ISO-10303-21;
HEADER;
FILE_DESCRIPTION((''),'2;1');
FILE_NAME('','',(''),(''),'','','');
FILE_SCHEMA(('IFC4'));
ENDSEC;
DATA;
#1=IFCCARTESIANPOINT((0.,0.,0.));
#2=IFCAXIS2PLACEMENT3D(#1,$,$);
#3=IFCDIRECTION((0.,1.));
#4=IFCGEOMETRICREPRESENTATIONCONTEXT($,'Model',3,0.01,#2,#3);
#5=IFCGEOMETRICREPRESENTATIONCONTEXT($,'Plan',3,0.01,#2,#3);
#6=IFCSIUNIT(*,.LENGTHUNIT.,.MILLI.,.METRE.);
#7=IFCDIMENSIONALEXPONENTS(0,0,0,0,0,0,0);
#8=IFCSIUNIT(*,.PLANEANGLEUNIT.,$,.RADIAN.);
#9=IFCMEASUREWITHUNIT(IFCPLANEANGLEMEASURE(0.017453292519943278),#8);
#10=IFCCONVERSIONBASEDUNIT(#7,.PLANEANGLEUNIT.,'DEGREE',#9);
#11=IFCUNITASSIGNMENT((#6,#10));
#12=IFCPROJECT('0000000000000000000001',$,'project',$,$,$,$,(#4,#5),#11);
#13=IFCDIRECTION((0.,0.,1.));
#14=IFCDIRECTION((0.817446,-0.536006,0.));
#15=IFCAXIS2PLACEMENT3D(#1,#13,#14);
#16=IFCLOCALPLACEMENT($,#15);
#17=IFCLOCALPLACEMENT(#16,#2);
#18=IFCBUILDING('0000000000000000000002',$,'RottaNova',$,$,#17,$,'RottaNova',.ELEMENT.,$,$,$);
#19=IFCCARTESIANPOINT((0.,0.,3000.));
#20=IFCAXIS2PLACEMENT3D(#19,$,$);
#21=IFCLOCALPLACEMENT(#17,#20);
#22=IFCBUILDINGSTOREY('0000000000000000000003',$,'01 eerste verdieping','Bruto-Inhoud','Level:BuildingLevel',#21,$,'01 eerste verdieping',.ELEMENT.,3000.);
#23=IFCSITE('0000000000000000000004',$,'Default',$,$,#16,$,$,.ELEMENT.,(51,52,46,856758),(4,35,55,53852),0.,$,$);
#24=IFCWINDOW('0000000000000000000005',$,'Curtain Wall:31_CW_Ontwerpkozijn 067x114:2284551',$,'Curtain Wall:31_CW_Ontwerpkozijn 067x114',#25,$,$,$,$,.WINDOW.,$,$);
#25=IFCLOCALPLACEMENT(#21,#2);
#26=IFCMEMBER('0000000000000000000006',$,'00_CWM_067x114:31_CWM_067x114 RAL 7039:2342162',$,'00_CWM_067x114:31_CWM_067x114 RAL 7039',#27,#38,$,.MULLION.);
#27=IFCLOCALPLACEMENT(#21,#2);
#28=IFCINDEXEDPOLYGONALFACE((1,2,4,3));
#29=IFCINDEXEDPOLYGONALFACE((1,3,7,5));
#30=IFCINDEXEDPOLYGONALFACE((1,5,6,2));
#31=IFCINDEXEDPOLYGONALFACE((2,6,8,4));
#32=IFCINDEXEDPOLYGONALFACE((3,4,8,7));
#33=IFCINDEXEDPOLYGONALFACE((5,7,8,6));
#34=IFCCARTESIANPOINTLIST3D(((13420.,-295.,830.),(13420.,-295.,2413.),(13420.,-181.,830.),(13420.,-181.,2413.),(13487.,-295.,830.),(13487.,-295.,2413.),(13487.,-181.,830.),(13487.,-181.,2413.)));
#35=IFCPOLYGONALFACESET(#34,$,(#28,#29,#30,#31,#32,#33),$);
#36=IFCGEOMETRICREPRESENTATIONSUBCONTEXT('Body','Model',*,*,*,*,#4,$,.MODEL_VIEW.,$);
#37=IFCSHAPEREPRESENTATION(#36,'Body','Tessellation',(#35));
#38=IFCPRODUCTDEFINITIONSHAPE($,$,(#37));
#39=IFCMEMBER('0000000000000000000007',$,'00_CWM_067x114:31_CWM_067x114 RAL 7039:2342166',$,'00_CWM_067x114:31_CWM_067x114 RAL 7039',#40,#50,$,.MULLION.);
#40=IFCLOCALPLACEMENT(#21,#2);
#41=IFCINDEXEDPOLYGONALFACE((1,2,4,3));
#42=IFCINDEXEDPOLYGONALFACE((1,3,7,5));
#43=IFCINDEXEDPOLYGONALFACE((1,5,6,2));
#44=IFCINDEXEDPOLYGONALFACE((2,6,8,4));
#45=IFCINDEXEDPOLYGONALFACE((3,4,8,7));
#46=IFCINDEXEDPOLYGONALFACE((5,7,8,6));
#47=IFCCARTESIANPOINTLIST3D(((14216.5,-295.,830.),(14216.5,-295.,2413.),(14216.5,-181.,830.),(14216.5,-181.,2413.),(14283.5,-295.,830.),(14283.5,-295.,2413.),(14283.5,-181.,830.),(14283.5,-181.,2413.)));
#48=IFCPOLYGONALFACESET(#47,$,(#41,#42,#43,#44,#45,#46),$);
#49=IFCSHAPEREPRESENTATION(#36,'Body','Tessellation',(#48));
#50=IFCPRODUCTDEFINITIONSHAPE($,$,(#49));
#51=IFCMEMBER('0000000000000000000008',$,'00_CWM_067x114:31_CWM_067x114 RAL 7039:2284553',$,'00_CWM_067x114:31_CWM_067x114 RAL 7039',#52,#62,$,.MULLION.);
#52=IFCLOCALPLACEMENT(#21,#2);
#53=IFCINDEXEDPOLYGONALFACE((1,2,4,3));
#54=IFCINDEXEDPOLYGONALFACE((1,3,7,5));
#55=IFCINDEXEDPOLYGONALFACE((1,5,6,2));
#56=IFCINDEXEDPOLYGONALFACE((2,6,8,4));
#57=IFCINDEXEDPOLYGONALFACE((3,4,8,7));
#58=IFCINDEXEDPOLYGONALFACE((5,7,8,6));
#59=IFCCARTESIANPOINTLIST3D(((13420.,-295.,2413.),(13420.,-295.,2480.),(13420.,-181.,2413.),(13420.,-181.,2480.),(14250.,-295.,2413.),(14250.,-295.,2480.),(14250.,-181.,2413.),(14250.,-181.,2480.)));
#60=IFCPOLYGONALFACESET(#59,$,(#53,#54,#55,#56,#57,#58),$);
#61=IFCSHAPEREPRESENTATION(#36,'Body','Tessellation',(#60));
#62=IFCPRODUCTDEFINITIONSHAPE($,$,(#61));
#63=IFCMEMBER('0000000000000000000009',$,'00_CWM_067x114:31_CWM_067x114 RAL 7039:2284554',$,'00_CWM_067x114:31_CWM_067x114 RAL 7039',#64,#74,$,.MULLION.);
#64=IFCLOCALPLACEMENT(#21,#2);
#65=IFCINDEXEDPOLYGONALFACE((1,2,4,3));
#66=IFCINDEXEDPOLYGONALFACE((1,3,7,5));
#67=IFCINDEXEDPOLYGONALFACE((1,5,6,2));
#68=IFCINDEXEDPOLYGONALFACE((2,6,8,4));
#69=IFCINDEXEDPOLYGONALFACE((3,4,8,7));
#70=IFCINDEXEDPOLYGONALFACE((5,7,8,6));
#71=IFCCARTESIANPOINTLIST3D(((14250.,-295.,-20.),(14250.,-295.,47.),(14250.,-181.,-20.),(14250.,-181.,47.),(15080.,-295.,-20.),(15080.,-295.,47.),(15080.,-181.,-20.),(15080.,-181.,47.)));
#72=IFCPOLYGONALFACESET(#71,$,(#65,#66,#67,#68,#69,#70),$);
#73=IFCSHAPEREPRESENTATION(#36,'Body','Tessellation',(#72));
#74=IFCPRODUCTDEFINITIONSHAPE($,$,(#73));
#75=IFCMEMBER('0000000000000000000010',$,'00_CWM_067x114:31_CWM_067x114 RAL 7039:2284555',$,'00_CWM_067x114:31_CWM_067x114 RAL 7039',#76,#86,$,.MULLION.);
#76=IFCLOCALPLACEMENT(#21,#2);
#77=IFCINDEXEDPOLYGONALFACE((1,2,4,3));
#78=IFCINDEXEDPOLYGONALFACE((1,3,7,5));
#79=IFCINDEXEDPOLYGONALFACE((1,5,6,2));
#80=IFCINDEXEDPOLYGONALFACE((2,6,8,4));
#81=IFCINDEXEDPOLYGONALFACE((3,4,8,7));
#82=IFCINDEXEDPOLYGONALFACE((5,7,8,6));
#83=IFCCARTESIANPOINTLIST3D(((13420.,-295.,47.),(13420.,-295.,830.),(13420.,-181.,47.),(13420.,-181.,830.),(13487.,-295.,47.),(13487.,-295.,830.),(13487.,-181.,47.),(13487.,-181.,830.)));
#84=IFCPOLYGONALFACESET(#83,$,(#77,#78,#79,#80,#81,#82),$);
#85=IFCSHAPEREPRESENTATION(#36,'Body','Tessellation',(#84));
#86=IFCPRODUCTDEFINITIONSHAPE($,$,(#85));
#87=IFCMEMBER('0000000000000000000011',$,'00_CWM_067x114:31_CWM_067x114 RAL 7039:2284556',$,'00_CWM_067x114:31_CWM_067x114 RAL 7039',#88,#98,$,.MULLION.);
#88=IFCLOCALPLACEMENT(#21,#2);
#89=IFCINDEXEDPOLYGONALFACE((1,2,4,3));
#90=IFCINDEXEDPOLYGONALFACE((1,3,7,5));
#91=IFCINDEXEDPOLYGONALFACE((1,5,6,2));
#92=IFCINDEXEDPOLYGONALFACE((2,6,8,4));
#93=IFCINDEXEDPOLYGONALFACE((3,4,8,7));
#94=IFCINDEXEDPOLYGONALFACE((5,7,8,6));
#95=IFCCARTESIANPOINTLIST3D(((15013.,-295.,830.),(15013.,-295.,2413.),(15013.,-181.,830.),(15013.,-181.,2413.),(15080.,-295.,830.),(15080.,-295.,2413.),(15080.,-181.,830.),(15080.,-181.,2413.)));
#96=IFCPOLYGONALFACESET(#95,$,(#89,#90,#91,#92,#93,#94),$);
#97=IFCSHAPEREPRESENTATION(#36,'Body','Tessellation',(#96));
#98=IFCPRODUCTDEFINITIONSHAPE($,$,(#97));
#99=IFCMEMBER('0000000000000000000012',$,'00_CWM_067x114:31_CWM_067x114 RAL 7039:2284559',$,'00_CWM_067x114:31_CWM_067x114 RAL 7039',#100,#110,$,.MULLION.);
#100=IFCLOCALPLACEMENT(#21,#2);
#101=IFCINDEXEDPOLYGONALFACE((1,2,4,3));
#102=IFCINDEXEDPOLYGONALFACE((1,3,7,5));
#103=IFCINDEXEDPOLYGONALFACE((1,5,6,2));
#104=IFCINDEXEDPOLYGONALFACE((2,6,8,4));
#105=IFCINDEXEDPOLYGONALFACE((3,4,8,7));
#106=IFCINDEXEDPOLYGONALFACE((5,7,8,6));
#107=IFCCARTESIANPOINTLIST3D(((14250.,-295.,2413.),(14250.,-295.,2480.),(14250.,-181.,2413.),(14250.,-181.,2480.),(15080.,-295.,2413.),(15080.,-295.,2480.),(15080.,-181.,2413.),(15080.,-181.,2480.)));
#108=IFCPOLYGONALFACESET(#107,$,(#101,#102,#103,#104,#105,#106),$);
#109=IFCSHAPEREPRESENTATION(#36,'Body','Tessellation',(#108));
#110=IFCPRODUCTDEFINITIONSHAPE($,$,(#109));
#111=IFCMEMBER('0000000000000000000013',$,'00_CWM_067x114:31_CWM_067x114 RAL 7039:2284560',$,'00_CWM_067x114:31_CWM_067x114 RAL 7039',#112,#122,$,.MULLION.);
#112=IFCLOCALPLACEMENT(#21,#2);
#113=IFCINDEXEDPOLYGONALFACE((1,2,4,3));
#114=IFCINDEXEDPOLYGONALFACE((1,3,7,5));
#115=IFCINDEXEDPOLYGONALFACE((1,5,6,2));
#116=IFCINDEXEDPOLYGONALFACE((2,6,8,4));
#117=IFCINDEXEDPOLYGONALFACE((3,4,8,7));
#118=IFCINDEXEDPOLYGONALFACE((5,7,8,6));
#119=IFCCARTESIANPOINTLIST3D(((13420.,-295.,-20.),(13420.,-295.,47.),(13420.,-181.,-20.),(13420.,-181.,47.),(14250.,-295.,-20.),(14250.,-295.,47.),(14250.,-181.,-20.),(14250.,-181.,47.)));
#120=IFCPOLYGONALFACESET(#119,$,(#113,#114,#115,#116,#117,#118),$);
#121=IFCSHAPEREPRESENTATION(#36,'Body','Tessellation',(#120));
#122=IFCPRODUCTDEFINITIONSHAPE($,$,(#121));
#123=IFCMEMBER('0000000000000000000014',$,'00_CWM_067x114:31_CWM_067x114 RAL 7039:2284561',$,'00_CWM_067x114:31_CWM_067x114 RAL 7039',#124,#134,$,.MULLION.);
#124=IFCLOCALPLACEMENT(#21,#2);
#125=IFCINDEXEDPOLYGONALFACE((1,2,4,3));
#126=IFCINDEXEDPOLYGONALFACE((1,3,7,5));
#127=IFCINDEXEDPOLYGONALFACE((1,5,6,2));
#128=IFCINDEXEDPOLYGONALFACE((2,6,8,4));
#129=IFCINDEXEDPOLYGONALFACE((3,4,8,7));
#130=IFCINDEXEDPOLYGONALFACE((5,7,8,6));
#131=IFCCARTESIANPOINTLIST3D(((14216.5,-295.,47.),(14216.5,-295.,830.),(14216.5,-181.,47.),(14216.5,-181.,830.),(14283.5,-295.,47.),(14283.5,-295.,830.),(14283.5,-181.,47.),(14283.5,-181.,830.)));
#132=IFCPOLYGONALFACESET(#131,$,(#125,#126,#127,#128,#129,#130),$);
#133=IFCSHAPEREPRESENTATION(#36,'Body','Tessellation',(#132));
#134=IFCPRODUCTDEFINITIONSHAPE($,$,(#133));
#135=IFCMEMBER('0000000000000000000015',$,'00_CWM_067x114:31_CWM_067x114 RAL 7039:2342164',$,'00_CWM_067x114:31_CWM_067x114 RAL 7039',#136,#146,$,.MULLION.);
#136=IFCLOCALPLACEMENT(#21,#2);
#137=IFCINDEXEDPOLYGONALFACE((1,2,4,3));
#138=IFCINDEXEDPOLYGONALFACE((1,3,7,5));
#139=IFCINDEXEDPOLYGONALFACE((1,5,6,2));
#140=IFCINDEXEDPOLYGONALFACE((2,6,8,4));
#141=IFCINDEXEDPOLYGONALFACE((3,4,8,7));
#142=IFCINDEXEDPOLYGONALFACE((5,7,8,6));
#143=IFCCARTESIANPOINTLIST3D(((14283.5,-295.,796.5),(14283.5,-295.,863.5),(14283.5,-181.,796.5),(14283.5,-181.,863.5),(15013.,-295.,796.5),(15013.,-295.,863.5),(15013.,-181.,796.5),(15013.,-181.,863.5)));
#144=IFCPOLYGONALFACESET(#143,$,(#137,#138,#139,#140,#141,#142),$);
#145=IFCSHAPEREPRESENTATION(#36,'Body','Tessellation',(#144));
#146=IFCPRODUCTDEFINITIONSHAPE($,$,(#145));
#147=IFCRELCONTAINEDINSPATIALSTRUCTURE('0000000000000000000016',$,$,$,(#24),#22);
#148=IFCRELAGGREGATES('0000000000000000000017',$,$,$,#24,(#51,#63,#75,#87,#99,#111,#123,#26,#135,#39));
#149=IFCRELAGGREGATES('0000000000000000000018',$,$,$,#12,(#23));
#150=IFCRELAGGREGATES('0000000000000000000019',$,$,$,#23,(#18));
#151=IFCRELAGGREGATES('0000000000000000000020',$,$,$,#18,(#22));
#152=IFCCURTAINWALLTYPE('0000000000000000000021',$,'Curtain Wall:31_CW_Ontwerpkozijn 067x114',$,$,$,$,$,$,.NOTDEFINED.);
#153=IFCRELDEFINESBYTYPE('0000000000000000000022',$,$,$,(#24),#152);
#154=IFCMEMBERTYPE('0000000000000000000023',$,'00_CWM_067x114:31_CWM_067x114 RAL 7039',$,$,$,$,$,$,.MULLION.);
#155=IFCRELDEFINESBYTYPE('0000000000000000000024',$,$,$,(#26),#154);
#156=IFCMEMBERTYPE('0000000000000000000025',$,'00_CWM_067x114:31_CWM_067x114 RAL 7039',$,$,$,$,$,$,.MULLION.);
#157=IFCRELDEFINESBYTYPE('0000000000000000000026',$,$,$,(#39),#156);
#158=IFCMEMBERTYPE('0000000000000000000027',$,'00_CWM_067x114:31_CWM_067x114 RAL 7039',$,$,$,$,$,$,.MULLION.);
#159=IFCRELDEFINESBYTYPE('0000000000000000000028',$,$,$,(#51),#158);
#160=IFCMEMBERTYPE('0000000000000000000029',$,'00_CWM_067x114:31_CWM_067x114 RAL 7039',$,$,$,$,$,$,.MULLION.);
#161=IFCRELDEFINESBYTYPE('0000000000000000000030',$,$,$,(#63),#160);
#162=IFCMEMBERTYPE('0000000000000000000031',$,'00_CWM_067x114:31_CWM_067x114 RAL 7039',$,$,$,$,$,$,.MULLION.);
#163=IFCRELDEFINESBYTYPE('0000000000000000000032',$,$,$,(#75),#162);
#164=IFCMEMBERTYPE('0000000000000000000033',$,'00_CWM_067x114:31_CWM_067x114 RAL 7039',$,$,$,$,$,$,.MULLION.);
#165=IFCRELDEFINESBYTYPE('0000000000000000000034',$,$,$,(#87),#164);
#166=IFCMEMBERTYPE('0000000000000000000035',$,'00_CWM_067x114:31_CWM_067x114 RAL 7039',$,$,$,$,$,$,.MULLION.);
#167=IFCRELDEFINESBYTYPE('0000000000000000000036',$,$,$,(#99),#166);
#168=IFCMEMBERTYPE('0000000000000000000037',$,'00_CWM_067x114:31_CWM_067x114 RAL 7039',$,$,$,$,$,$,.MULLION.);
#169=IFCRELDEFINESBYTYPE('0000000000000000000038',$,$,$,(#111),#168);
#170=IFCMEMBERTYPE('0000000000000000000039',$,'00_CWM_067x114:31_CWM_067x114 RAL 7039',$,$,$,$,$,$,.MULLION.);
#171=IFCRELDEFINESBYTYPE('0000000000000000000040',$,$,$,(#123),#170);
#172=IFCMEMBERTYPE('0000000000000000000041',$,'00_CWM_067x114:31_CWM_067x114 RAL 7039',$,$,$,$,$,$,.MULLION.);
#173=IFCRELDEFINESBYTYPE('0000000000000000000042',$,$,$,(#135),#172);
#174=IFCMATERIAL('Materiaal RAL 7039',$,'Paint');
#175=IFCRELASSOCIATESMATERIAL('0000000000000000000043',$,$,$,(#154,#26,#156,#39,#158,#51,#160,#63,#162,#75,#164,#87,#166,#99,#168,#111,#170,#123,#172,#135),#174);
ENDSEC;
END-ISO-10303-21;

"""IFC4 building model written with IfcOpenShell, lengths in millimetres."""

from ifc_helpers import new_model, entity, si_unit, converted_unit, direction, frame, origin, place, context, subcontext, project, spatial, indexed_curve, outline, extrude, source, transform, mapped, material, type_object, type_shapes, element, aggregate, save


model = new_model("IFC4")

# Units and contexts
model_context = context("Model", 3, precision=0.01, world=origin(), true_north=direction((0.0, 1.0)))
plan_context = context("Plan", 3, precision=0.01, world=origin(), true_north=direction((0.0, 1.0)))
body_context = subcontext(model_context, "Body", "Model", "MODEL_VIEW")
ifc_project = project(units=[si_unit("LENGTHUNIT", "METRE", prefix="MILLI"), converted_unit("PLANEANGLEUNIT", "DEGREE", entity("IfcPlaneAngleMeasure", 0.017453292519943278), si_unit("PLANEANGLEUNIT", "RADIAN"), dimensions=[0, 0, 0, 0, 0, 0, 0])], contexts=[model_context, plan_context])

# Site, building, storey
site_placement = place(None, frame((0.0, 0.0, 0.0), z_axis=(0.0, 0.0, 1.0), x_axis=(0.817446, -0.536006, 0.0)))
site = spatial("IfcSite", under=ifc_project, at=site_placement, Name="Default", CompositionType="ELEMENT", RefLatitude=(51, 52, 46, 856758), RefLongitude=(4, 35, 55, 53852), RefElevation=0.0)
building_placement = place(site_placement, origin())
building = spatial("IfcBuilding", under=site, at=building_placement, Name="RottaNova", LongName="RottaNova", CompositionType="ELEMENT")
storey_placement = place(building_placement, frame((0.0, 0.0, 3000.0)))
storey = spatial("IfcBuildingStorey", under=building, at=storey_placement, Name="01 eerste verdieping", Description="Bruto-Inhoud", ObjectType="Level:BuildingLevel", LongName="01 eerste verdieping", CompositionType="ELEMENT", Elevation=3000.0)

# Window, members
curtain_wall_type = type_object("IfcCurtainWallType", Name="Curtain Wall:31_CW_Ontwerpkozijn 067x114", PredefinedType="NOTDEFINED")
window_placement = place(storey_placement, frame((0.0, 0.0, -3000.0)))
window = element("IfcWindow", 1, at=window_placement, inside=storey, type_object=curtain_wall_type, Name="Curtain Wall:31_CW_Ontwerpkozijn 067x114:2284551", ObjectType="Curtain Wall:31_CW_Ontwerpkozijn 067x114", PredefinedType="WINDOW")
ifc_material_1 = material(Name="Materiaal RAL 7039", Category="Paint")
member_type_1 = type_object("IfcMemberType", Name="00_CWM_067x114:31_CWM_067x114 RAL 7039", PredefinedType="MULLION", material=ifc_material_1)
shared_shape_1 = source(origin(), body_context, "Body", "SweptSolid", [
    extrude(outline(indexed_curve([(-33.5, -57.0), (33.5, -57.0), (33.5, 57.0), (-33.5, 57.0), (-33.5, -57.0)], self_intersect=False)), frame((-33.5, -57.0, -1583.0), z_axis=(0.0, 0.0, 1.0), x_axis=(-1.0, 0.0, 0.0)), (0.0, 0.0, 1.0), 1583.0),
])
type_shapes(member_type_1, [shared_shape_1])
member_1_placement = place(window_placement, frame((13420.0, -181.0, 3830.0), z_axis=(0.0, 0.0, -1.0), x_axis=(-1.0, 0.0, 0.0)))
member_1 = element("IfcMember", 2, at=member_1_placement, type_object=member_type_1, material=ifc_material_1, Name="00_CWM_067x114:31_CWM_067x114 RAL 7039:2342162", ObjectType="00_CWM_067x114:31_CWM_067x114 RAL 7039", PredefinedType="MULLION", context=body_context, shape_type="MappedRepresentation", body=[
    mapped(shared_shape_1, transform((0.0, 0.0, 0.0), scale=1.0)),
])
member_type_2 = type_object("IfcMemberType", Name="00_CWM_067x114:31_CWM_067x114 RAL 7039", PredefinedType="MULLION", material=ifc_material_1)
shared_shape_2 = source(origin(), body_context, "Body", "SweptSolid", [
    extrude(outline(indexed_curve([(-33.5, -57.0), (33.5, -57.0), (33.5, 57.0), (-33.5, 57.0), (-33.5, -57.0)], self_intersect=False)), frame((0.0, -57.0, -1583.0), z_axis=(0.0, 0.0, 1.0), x_axis=(-1.0, 0.0, 0.0)), (0.0, 0.0, 1.0), 1583.0),
])
type_shapes(member_type_2, [shared_shape_2])
member_2_placement = place(window_placement, frame((14250.0, -181.0, 3830.0), z_axis=(0.0, 0.0, -1.0), x_axis=(-1.0, 0.0, 0.0)))
member_2 = element("IfcMember", 3, at=member_2_placement, type_object=member_type_2, material=ifc_material_1, Name="00_CWM_067x114:31_CWM_067x114 RAL 7039:2342166", ObjectType="00_CWM_067x114:31_CWM_067x114 RAL 7039", PredefinedType="MULLION", context=body_context, shape_type="MappedRepresentation", body=[
    mapped(shared_shape_2, transform((0.0, 0.0, 0.0), scale=1.0)),
])
member_type_3 = type_object("IfcMemberType", Name="00_CWM_067x114:31_CWM_067x114 RAL 7039", PredefinedType="MULLION", material=ifc_material_1)
shared_shape_3 = source(origin(), body_context, "Body", "SweptSolid", [
    extrude(outline(indexed_curve([(-33.5, -57.0), (33.5, -57.0), (33.5, 57.0), (-33.5, 57.0), (-33.5, -57.0)], self_intersect=False)), frame((-33.5, -57.0, -830.0), z_axis=(0.0, 0.0, 1.0), x_axis=(-1.0, 0.0, 0.0)), (0.0, 0.0, 1.0), 830.0),
])
type_shapes(member_type_3, [shared_shape_3])
member_3_placement = place(window_placement, frame((13420.0, -181.0, 5480.0), z_axis=(-1.0, 0.0, 0.0), x_axis=(0.0, 0.0, 1.0)))
member_3 = element("IfcMember", 4, at=member_3_placement, type_object=member_type_3, material=ifc_material_1, Name="00_CWM_067x114:31_CWM_067x114 RAL 7039:2284553", ObjectType="00_CWM_067x114:31_CWM_067x114 RAL 7039", PredefinedType="MULLION", context=body_context, shape_type="MappedRepresentation", body=[
    mapped(shared_shape_3, transform((0.0, 0.0, 0.0), scale=1.0)),
])
member_type_4 = type_object("IfcMemberType", Name="00_CWM_067x114:31_CWM_067x114 RAL 7039", PredefinedType="MULLION", material=ifc_material_1)
shared_shape_4 = source(origin(), body_context, "Body", "SweptSolid", [
    extrude(outline(indexed_curve([(-33.5, -57.0), (33.5, -57.0), (33.5, 57.0), (-33.5, 57.0), (-33.5, -57.0)], self_intersect=False)), frame((-33.5, -57.0, -830.0), z_axis=(0.0, 0.0, 1.0), x_axis=(-1.0, 0.0, 0.0)), (0.0, 0.0, 1.0), 830.0),
])
type_shapes(member_type_4, [shared_shape_4])
member_4_placement = place(window_placement, frame((15080.0, -181.0, 2980.0), z_axis=(1.0, 0.0, 0.0), x_axis=(0.0, 0.0, -1.0)))
member_4 = element("IfcMember", 5, at=member_4_placement, type_object=member_type_4, material=ifc_material_1, Name="00_CWM_067x114:31_CWM_067x114 RAL 7039:2284554", ObjectType="00_CWM_067x114:31_CWM_067x114 RAL 7039", PredefinedType="MULLION", context=body_context, shape_type="MappedRepresentation", body=[
    mapped(shared_shape_4, transform((0.0, 0.0, 0.0), scale=1.0)),
])
member_type_5 = type_object("IfcMemberType", Name="00_CWM_067x114:31_CWM_067x114 RAL 7039", PredefinedType="MULLION", material=ifc_material_1)
shared_shape_5 = source(origin(), body_context, "Body", "SweptSolid", [
    extrude(outline(indexed_curve([(-33.5, -57.0), (33.5, -57.0), (33.5, 57.0), (-33.5, 57.0), (-33.5, -57.0)], self_intersect=False)), frame((-33.5, -57.0, -783.0), z_axis=(0.0, 0.0, 1.0), x_axis=(-1.0, 0.0, 0.0)), (0.0, 0.0, 1.0), 783.0),
])
type_shapes(member_type_5, [shared_shape_5])
member_5_placement = place(window_placement, frame((13420.0, -181.0, 3047.0), z_axis=(0.0, 0.0, -1.0), x_axis=(-1.0, 0.0, 0.0)))
member_5 = element("IfcMember", 6, at=member_5_placement, type_object=member_type_5, material=ifc_material_1, Name="00_CWM_067x114:31_CWM_067x114 RAL 7039:2284555", ObjectType="00_CWM_067x114:31_CWM_067x114 RAL 7039", PredefinedType="MULLION", context=body_context, shape_type="MappedRepresentation", body=[
    mapped(shared_shape_5, transform((0.0, 0.0, 0.0), scale=1.0)),
])
member_type_6 = type_object("IfcMemberType", Name="00_CWM_067x114:31_CWM_067x114 RAL 7039", PredefinedType="MULLION", material=ifc_material_1)
shared_shape_6 = source(origin(), body_context, "Body", "SweptSolid", [
    extrude(outline(indexed_curve([(-33.5, -57.0), (33.5, -57.0), (33.5, 57.0), (-33.5, 57.0), (-33.5, -57.0)], self_intersect=False)), frame((-33.5, -57.0, -1583.0), z_axis=(0.0, 0.0, 1.0), x_axis=(-1.0, 0.0, 0.0)), (0.0, 0.0, 1.0), 1583.0),
])
type_shapes(member_type_6, [shared_shape_6])
member_6_placement = place(window_placement, frame((15080.0, -181.0, 5413.0)))
member_6 = element("IfcMember", 7, at=member_6_placement, type_object=member_type_6, material=ifc_material_1, Name="00_CWM_067x114:31_CWM_067x114 RAL 7039:2284556", ObjectType="00_CWM_067x114:31_CWM_067x114 RAL 7039", PredefinedType="MULLION", context=body_context, shape_type="MappedRepresentation", body=[
    mapped(shared_shape_6, transform((0.0, 0.0, 0.0), scale=1.0)),
])
member_type_7 = type_object("IfcMemberType", Name="00_CWM_067x114:31_CWM_067x114 RAL 7039", PredefinedType="MULLION", material=ifc_material_1)
shared_shape_7 = source(origin(), body_context, "Body", "SweptSolid", [
    extrude(outline(indexed_curve([(-33.5, -57.0), (33.5, -57.0), (33.5, 57.0), (-33.5, 57.0), (-33.5, -57.0)], self_intersect=False)), frame((-33.5, -57.0, -830.0), z_axis=(0.0, 0.0, 1.0), x_axis=(-1.0, 0.0, 0.0)), (0.0, 0.0, 1.0), 830.0),
])
type_shapes(member_type_7, [shared_shape_7])
member_7_placement = place(window_placement, frame((14250.0, -181.0, 5480.0), z_axis=(-1.0, 0.0, 0.0), x_axis=(0.0, 0.0, 1.0)))
member_7 = element("IfcMember", 8, at=member_7_placement, type_object=member_type_7, material=ifc_material_1, Name="00_CWM_067x114:31_CWM_067x114 RAL 7039:2284559", ObjectType="00_CWM_067x114:31_CWM_067x114 RAL 7039", PredefinedType="MULLION", context=body_context, shape_type="MappedRepresentation", body=[
    mapped(shared_shape_7, transform((0.0, 0.0, 0.0), scale=1.0)),
])
member_type_8 = type_object("IfcMemberType", Name="00_CWM_067x114:31_CWM_067x114 RAL 7039", PredefinedType="MULLION", material=ifc_material_1)
shared_shape_8 = source(origin(), body_context, "Body", "SweptSolid", [
    extrude(outline(indexed_curve([(-33.5, -57.0), (33.5, -57.0), (33.5, 57.0), (-33.5, 57.0), (-33.5, -57.0)], self_intersect=False)), frame((-33.5, -57.0, -830.0), z_axis=(0.0, 0.0, 1.0), x_axis=(-1.0, 0.0, 0.0)), (0.0, 0.0, 1.0), 830.0),
])
type_shapes(member_type_8, [shared_shape_8])
member_8_placement = place(window_placement, frame((14250.0, -181.0, 2980.0), z_axis=(1.0, 0.0, 0.0), x_axis=(0.0, 0.0, -1.0)))
member_8 = element("IfcMember", 9, at=member_8_placement, type_object=member_type_8, material=ifc_material_1, Name="00_CWM_067x114:31_CWM_067x114 RAL 7039:2284560", ObjectType="00_CWM_067x114:31_CWM_067x114 RAL 7039", PredefinedType="MULLION", context=body_context, shape_type="MappedRepresentation", body=[
    mapped(shared_shape_8, transform((0.0, 0.0, 0.0), scale=1.0)),
])
member_type_9 = type_object("IfcMemberType", Name="00_CWM_067x114:31_CWM_067x114 RAL 7039", PredefinedType="MULLION", material=ifc_material_1)
shared_shape_9 = source(origin(), body_context, "Body", "SweptSolid", [
    extrude(outline(indexed_curve([(-33.5, -57.0), (33.5, -57.0), (33.5, 57.0), (-33.5, 57.0), (-33.5, -57.0)], self_intersect=False)), frame((0.0, -57.0, -783.0), z_axis=(0.0, 0.0, 1.0), x_axis=(-1.0, 0.0, 0.0)), (0.0, 0.0, 1.0), 783.0),
])
type_shapes(member_type_9, [shared_shape_9])
member_9_placement = place(window_placement, frame((14250.0, -181.0, 3047.0), z_axis=(0.0, 0.0, -1.0), x_axis=(-1.0, 0.0, 0.0)))
member_9 = element("IfcMember", 10, at=member_9_placement, type_object=member_type_9, material=ifc_material_1, Name="00_CWM_067x114:31_CWM_067x114 RAL 7039:2284561", ObjectType="00_CWM_067x114:31_CWM_067x114 RAL 7039", PredefinedType="MULLION", context=body_context, shape_type="MappedRepresentation", body=[
    mapped(shared_shape_9, transform((0.0, 0.0, 0.0), scale=1.0)),
])
member_type_10 = type_object("IfcMemberType", Name="00_CWM_067x114:31_CWM_067x114 RAL 7039", PredefinedType="MULLION", material=ifc_material_1)
shared_shape_10 = source(origin(), body_context, "Body", "SweptSolid", [
    extrude(outline(indexed_curve([(-33.5, -57.0), (33.5, -57.0), (33.5, 57.0), (-33.5, 57.0), (-33.5, -57.0)], self_intersect=False)), frame((0.0, -57.0, -729.5), z_axis=(0.0, 0.0, 1.0), x_axis=(-1.0, 0.0, 0.0)), (0.0, 0.0, 1.0), 729.5),
])
type_shapes(member_type_10, [shared_shape_10])
member_10_placement = place(window_placement, frame((14283.5, -181.0, 3830.0), z_axis=(-1.0, 0.0, 0.0), x_axis=(0.0, 0.0, 1.0)))
member_10 = element("IfcMember", 11, at=member_10_placement, type_object=member_type_10, material=ifc_material_1, Name="00_CWM_067x114:31_CWM_067x114 RAL 7039:2342164", ObjectType="00_CWM_067x114:31_CWM_067x114 RAL 7039", PredefinedType="MULLION", context=body_context, shape_type="MappedRepresentation", body=[
    mapped(shared_shape_10, transform((0.0, 0.0, 0.0), scale=1.0)),
])
aggregate(window, [member_3, member_4, member_5, member_6, member_7, member_8, member_9, member_1, member_10, member_2])

save(model, "model.ifc")
